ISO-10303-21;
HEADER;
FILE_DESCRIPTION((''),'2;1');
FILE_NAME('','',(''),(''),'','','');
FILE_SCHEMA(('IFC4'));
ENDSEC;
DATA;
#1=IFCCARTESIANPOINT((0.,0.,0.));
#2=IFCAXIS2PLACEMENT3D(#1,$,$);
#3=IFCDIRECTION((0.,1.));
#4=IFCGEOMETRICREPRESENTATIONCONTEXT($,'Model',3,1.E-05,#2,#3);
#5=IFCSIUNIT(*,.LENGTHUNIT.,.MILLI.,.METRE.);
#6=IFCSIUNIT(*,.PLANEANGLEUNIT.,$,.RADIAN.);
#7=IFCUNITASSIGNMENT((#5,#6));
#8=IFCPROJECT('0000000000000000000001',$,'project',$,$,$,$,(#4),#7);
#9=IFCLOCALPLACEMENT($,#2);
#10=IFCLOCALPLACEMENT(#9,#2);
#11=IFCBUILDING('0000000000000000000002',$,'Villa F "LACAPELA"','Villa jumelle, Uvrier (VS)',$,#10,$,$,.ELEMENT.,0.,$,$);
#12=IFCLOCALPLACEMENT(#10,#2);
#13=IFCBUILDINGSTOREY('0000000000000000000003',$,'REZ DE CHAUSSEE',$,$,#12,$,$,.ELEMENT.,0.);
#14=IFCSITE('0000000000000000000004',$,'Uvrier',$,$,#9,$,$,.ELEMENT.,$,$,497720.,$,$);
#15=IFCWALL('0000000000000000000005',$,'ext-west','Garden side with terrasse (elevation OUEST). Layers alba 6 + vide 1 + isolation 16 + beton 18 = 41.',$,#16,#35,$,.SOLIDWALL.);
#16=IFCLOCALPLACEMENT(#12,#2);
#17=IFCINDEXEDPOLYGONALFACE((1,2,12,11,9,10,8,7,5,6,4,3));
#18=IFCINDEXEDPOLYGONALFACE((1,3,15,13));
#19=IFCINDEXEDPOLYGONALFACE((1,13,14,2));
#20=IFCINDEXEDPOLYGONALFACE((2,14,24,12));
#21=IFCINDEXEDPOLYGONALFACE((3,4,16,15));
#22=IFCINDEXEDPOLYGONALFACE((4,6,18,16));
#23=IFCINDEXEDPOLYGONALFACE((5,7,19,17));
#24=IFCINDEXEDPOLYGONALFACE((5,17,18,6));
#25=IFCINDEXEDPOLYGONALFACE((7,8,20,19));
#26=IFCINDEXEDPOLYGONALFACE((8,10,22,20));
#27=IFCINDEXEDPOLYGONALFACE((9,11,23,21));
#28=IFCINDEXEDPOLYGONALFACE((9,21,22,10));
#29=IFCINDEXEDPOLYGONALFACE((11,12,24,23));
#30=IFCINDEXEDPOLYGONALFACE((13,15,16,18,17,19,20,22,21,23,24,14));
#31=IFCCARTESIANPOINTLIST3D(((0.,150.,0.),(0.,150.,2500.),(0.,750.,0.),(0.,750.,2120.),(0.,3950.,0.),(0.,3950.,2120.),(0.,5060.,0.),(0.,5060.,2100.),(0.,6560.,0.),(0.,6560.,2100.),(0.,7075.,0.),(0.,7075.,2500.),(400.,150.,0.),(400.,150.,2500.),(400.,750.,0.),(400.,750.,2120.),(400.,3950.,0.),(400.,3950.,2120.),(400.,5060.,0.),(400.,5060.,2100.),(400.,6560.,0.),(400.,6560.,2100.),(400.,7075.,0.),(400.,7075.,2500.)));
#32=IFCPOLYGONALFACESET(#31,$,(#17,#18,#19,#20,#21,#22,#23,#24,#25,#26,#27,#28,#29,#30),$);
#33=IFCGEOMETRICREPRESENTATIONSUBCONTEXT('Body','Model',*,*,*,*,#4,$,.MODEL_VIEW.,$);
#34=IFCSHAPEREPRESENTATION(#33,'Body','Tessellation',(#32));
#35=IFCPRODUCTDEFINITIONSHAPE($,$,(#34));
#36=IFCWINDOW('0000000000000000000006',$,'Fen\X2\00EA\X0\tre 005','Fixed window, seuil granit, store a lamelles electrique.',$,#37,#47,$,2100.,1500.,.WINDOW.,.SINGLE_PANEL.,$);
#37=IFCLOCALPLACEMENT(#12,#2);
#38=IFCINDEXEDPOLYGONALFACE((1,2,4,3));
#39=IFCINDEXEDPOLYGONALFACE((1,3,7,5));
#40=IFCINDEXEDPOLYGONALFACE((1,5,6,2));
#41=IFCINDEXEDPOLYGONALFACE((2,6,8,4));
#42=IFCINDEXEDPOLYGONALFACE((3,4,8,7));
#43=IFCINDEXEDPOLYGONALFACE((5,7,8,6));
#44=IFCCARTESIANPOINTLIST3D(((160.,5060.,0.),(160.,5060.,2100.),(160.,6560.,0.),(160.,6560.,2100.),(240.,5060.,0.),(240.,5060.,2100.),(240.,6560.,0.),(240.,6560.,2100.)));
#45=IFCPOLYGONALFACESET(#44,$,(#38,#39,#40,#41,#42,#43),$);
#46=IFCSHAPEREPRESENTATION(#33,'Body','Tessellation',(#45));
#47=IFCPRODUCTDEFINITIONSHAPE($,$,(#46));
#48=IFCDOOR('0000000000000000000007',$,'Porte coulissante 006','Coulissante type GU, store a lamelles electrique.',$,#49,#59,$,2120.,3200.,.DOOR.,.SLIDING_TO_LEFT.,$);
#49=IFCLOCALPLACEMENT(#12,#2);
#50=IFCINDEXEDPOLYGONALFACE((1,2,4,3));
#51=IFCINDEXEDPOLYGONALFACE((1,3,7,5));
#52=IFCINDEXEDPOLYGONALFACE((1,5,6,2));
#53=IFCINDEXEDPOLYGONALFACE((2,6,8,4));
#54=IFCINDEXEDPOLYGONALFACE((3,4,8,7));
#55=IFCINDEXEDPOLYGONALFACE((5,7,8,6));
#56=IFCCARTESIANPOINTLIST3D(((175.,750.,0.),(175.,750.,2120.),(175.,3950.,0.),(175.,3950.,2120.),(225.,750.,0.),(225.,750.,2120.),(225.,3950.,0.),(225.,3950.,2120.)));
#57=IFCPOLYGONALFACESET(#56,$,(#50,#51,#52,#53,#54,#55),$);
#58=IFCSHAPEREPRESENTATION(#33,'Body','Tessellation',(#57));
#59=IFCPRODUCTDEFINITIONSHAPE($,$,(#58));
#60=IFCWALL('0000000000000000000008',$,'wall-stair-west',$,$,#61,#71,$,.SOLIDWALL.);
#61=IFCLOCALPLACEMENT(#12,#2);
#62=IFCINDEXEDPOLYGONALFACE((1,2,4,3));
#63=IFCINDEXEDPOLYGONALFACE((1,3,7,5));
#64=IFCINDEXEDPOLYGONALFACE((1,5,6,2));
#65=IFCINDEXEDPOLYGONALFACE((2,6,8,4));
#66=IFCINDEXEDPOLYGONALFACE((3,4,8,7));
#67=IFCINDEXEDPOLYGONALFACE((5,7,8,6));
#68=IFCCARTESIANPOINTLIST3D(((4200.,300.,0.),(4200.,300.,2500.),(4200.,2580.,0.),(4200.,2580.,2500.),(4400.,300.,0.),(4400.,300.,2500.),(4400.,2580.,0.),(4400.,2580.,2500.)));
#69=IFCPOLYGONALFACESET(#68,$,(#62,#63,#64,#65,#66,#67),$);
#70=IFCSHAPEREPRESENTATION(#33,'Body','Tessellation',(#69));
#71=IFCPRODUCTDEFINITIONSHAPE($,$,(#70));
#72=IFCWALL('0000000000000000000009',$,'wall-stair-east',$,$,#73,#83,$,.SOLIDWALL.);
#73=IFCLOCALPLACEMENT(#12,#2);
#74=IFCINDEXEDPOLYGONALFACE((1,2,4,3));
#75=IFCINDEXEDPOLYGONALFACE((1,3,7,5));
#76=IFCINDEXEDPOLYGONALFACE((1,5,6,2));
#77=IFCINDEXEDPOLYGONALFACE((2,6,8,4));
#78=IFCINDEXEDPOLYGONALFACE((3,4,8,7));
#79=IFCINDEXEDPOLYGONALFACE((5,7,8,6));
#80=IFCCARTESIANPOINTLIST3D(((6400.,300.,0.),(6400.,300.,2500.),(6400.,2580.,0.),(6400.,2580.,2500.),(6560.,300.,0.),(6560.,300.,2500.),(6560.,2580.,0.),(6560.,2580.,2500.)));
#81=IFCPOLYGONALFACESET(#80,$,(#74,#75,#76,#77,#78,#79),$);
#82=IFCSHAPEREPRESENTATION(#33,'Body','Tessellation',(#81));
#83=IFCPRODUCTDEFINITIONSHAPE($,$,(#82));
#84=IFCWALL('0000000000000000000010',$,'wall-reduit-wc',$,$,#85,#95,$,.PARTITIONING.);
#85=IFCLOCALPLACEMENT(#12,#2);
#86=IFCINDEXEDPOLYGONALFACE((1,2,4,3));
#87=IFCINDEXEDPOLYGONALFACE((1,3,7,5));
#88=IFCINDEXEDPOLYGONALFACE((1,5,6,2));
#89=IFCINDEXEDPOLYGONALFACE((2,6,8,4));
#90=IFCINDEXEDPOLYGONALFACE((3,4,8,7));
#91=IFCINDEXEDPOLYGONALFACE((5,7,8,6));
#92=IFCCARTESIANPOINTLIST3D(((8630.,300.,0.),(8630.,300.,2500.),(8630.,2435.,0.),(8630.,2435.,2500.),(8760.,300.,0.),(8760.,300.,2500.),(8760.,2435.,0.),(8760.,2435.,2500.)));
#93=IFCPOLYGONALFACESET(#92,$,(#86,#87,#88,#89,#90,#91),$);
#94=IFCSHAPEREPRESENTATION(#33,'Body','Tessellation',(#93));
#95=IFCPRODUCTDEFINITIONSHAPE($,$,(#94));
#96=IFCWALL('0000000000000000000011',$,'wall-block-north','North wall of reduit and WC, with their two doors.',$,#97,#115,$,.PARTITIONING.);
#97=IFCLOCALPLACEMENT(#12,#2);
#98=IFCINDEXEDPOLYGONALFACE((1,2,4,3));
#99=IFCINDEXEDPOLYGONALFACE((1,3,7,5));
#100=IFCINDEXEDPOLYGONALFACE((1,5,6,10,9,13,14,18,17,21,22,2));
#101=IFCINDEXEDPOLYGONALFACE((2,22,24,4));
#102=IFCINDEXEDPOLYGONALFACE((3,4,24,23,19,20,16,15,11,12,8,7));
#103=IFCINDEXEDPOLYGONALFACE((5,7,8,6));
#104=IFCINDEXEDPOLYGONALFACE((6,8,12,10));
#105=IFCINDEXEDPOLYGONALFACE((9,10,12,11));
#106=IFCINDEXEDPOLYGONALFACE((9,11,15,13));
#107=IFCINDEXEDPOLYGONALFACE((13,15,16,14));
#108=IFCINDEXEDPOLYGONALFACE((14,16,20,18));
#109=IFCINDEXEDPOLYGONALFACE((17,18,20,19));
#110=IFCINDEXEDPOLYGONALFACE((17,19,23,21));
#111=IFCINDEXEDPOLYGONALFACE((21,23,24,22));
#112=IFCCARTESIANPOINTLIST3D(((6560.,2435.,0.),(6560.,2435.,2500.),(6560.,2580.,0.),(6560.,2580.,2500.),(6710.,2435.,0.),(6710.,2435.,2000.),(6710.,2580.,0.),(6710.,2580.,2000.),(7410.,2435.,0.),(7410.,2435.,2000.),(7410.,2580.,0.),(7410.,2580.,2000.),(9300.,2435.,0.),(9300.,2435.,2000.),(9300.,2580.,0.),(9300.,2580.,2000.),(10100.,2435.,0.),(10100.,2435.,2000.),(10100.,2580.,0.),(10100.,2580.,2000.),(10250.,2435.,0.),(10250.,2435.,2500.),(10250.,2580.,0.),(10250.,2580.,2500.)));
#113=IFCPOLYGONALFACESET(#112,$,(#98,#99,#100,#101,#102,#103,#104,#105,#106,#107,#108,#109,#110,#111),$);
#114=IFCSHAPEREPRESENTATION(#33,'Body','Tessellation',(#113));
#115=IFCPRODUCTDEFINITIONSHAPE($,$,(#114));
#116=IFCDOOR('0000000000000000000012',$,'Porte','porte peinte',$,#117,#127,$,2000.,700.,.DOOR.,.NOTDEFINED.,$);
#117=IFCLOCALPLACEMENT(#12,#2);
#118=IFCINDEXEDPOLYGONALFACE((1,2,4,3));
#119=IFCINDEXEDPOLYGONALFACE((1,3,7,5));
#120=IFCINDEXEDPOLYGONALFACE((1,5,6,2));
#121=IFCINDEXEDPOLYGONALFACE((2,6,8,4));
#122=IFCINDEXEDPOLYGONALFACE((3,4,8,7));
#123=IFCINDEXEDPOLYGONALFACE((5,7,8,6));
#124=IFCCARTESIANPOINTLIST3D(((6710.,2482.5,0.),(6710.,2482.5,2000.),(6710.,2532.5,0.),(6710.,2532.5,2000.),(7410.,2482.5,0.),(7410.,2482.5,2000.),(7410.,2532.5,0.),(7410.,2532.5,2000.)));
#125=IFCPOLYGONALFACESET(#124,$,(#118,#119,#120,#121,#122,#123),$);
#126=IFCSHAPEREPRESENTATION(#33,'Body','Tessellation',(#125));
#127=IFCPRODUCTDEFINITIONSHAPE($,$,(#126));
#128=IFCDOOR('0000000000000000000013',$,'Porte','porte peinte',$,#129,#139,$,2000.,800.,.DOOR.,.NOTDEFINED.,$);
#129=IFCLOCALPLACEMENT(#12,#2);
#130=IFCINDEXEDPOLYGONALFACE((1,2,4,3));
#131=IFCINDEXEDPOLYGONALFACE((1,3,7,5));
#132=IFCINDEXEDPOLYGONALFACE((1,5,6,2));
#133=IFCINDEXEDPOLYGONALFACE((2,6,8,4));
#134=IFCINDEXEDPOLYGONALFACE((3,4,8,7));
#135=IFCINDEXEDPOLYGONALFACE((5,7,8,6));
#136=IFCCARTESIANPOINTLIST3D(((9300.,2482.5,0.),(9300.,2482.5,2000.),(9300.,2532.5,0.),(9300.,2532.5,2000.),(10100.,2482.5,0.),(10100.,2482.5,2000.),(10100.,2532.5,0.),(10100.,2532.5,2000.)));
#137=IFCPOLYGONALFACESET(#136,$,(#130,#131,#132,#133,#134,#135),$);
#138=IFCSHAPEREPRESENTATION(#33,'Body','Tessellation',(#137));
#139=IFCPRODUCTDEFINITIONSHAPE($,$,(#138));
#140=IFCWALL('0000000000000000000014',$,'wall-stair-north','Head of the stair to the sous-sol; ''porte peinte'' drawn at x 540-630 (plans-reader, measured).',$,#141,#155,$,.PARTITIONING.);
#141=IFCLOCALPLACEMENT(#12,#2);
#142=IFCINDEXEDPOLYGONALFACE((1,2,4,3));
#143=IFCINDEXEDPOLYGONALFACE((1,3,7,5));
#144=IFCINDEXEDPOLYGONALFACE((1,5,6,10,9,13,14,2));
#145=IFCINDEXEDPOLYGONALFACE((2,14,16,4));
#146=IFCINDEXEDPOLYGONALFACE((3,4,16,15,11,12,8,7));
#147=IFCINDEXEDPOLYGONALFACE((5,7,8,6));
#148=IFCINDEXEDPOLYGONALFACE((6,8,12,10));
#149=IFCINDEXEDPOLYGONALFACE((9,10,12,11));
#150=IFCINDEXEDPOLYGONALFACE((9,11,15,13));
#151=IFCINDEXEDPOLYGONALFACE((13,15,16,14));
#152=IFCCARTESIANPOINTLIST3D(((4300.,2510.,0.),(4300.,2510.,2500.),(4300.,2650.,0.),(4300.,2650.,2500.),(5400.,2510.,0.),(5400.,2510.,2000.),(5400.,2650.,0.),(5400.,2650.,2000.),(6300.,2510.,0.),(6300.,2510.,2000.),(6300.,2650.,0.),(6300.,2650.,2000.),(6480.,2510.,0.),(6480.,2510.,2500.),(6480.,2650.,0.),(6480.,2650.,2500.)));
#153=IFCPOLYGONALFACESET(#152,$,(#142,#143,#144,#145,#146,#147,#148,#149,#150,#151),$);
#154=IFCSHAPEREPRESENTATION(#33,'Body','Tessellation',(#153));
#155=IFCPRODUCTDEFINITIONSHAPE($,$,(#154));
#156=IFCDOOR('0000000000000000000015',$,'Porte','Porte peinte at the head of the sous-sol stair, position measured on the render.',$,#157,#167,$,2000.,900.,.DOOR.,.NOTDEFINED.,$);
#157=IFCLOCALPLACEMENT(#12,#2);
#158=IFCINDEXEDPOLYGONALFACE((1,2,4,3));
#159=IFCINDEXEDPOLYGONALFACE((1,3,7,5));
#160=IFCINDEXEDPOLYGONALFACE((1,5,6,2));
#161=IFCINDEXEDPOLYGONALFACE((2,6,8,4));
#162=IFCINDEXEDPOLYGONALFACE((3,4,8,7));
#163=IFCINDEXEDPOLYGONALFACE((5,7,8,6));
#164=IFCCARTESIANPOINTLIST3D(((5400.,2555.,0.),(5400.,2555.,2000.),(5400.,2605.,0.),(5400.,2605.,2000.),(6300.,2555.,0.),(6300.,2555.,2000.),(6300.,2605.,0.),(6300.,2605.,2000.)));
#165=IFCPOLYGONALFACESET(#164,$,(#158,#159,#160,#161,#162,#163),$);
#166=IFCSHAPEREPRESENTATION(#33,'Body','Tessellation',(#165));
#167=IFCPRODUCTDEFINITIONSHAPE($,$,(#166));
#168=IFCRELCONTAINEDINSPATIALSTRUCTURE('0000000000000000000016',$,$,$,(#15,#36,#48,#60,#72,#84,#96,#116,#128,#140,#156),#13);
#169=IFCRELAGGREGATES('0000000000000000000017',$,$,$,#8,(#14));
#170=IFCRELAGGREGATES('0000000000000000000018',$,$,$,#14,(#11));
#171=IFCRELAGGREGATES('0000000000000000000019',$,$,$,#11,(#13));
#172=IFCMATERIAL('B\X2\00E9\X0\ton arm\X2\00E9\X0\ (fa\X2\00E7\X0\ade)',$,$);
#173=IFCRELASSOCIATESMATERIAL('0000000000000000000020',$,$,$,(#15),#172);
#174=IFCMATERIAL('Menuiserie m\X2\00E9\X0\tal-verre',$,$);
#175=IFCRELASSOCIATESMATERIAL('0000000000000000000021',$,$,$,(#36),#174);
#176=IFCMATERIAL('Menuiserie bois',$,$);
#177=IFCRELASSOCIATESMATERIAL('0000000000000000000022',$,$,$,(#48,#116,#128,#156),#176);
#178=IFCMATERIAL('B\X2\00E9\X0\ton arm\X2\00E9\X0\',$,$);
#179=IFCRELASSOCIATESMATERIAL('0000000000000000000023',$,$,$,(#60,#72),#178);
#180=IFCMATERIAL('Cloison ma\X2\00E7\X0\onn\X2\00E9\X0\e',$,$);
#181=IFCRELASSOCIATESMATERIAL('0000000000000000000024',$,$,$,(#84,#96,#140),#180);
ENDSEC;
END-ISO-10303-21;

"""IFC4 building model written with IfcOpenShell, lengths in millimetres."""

from ifc_helpers import new_model, si_unit, direction, frame, frame_2d, origin, place, context, subcontext, project, spatial, rectangle, extrude, material, element, fill, save


model = new_model("IFC4")

# Units and contexts
model_context = context("Model", 3, precision=1e-05, world=origin(), true_north=direction((0.0, 1.0)))
body_context = subcontext(model_context, "Body", "Model", "MODEL_VIEW")
ifc_project = project(units=[si_unit("LENGTHUNIT", "METRE", prefix="MILLI"), si_unit("PLANEANGLEUNIT", "RADIAN")], contexts=[model_context])

# Site, building, storey
site_placement = place(None, origin())
site = spatial("IfcSite", under=ifc_project, at=site_placement, Name="Uvrier", CompositionType="ELEMENT", RefElevation=497720.0)
building_placement = place(site_placement, origin())
building = spatial("IfcBuilding", under=site, at=building_placement, Name="Villa F \"LACAPELA\"", Description="Villa jumelle, Uvrier (VS)", CompositionType="ELEMENT", ElevationOfRefHeight=0.0)
storey_placement = place(building_placement, origin())
storey = spatial("IfcBuildingStorey", under=building, at=storey_placement, Name="REZ DE CHAUSSEE", CompositionType="ELEMENT", Elevation=0.0)

# Shared definitions
ifc_material_1 = material(Name="Béton armé")

# Shared definitions
ifc_material_2 = material(Name="Béton armé (façade)")

# Shared definitions
ifc_material_3 = material(Name="Menuiserie métal-verre")
ifc_material_4 = material(Name="Menuiserie bois")

# Wall, openings, window, door
wall_1_placement = place(storey_placement, frame((200.0, 150.0, 0.0), z_axis=(0.0, 0.0, 1.0), x_axis=(0.0, 1.0, 0.0)))
wall_1 = element("IfcWall", 1, at=wall_1_placement, inside=storey, material=ifc_material_2, Name="ext-west", Description="Garden side with terrasse (elevation OUEST). Layers alba 6 + vide 1 + isolation 16 + beton 18 = 41.", PredefinedType="SOLIDWALL", context=body_context, shape_type="SweptSolid", body=[
    extrude(rectangle(XDim=6925.0, YDim=400.0, at=frame_2d((3462.5, 0.0))), origin(), (0.0, 0.0, 1.0), 2500.0),
])
opening_1_placement = place(wall_1_placement, frame((4910.0, 0.0, 0.0)))
opening_1 = element("IfcOpeningElement", 2, at=opening_1_placement, cuts=wall_1, PredefinedType="OPENING", context=body_context, shape_type="SweptSolid", body=[
    extrude(rectangle(XDim=1500.0, YDim=600.0, at=frame_2d((750.0, 0.0))), origin(), (0.0, 0.0, 1.0), 2100.0),
])
opening_2_placement = place(wall_1_placement, frame((600.0, 0.0, 0.0)))
opening_2 = element("IfcOpeningElement", 3, at=opening_2_placement, cuts=wall_1, PredefinedType="OPENING", context=body_context, shape_type="SweptSolid", body=[
    extrude(rectangle(XDim=3200.0, YDim=600.0, at=frame_2d((1600.0, 0.0))), origin(), (0.0, 0.0, 1.0), 2120.0),
])
window_1_placement = place(opening_1_placement, origin())
window_1 = element("IfcWindow", 4, at=window_1_placement, inside=storey, material=ifc_material_3, Name="Fenêtre 005", Description="Fixed window, seuil granit, store a lamelles electrique.", OverallHeight=2100.0, OverallWidth=1500.0, PartitioningType="SINGLE_PANEL", PredefinedType="WINDOW", context=body_context, shape_type="SweptSolid", body=[
    extrude(rectangle(XDim=1500.0, YDim=80.0, at=frame_2d((750.0, 0.0))), origin(), (0.0, 0.0, 1.0), 2100.0),
])
fill(opening_1, window_1)
door_1_placement = place(opening_2_placement, origin())
door_1 = element("IfcDoor", 5, at=door_1_placement, inside=storey, material=ifc_material_4, Name="Porte coulissante 006", Description="Coulissante type GU, store a lamelles electrique.", OperationType="SLIDING_TO_LEFT", OverallHeight=2120.0, OverallWidth=3200.0, PredefinedType="DOOR", context=body_context, shape_type="SweptSolid", body=[
    extrude(rectangle(XDim=3200.0, YDim=50.0, at=frame_2d((1600.0, 0.0))), origin(), (0.0, 0.0, 1.0), 2120.0),
])
fill(opening_2, door_1)

# Walls
wall_2_placement = place(storey_placement, frame((4300.0, 300.0, 0.0), z_axis=(0.0, 0.0, 1.0), x_axis=(0.0, 1.0, 0.0)))
element("IfcWall", 6, at=wall_2_placement, inside=storey, material=ifc_material_1, Name="wall-stair-west", PredefinedType="SOLIDWALL", context=body_context, shape_type="SweptSolid", body=[
    extrude(rectangle(XDim=2280.0, YDim=200.0, at=frame_2d((1140.0, 0.0))), origin(), (0.0, 0.0, 1.0), 2500.0),
])
wall_3_placement = place(storey_placement, frame((6480.0, 300.0, 0.0), z_axis=(0.0, 0.0, 1.0), x_axis=(0.0, 1.0, 0.0)))
element("IfcWall", 7, at=wall_3_placement, inside=storey, material=ifc_material_1, Name="wall-stair-east", PredefinedType="SOLIDWALL", context=body_context, shape_type="SweptSolid", body=[
    extrude(rectangle(XDim=2280.0, YDim=160.0, at=frame_2d((1140.0, 0.0))), origin(), (0.0, 0.0, 1.0), 2500.0),
])
ifc_material_5 = material(Name="Cloison maçonnée")
wall_4_placement = place(storey_placement, frame((8695.0, 300.0, 0.0), z_axis=(0.0, 0.0, 1.0), x_axis=(0.0, 1.0, 0.0)))
element("IfcWall", 8, at=wall_4_placement, inside=storey, material=ifc_material_5, Name="wall-reduit-wc", PredefinedType="PARTITIONING", context=body_context, shape_type="SweptSolid", body=[
    extrude(rectangle(XDim=2135.0, YDim=130.0, at=frame_2d((1067.5, 0.0))), origin(), (0.0, 0.0, 1.0), 2500.0),
])

# Wall, openings, doors
wall_5_placement = place(storey_placement, frame((6560.0, 2507.5, 0.0), z_axis=(0.0, 0.0, 1.0), x_axis=(1.0, 0.0, 0.0)))
wall_5 = element("IfcWall", 9, at=wall_5_placement, inside=storey, material=ifc_material_5, Name="wall-block-north", Description="North wall of reduit and WC, with their two doors.", PredefinedType="PARTITIONING", context=body_context, shape_type="SweptSolid", body=[
    extrude(rectangle(XDim=3690.0, YDim=145.0, at=frame_2d((1845.0, 0.0))), origin(), (0.0, 0.0, 1.0), 2500.0),
])
opening_3_placement = place(wall_5_placement, frame((150.0, 0.0, 0.0)))
opening_3 = element("IfcOpeningElement", 10, at=opening_3_placement, cuts=wall_5, PredefinedType="OPENING", context=body_context, shape_type="SweptSolid", body=[
    extrude(rectangle(XDim=700.0, YDim=345.0, at=frame_2d((350.0, 0.0))), origin(), (0.0, 0.0, 1.0), 2000.0),
])
opening_4_placement = place(wall_5_placement, frame((2740.0, 0.0, 0.0)))
opening_4 = element("IfcOpeningElement", 11, at=opening_4_placement, cuts=wall_5, PredefinedType="OPENING", context=body_context, shape_type="SweptSolid", body=[
    extrude(rectangle(XDim=800.0, YDim=345.0, at=frame_2d((400.0, 0.0))), origin(), (0.0, 0.0, 1.0), 2000.0),
])
door_2_placement = place(opening_3_placement, origin())
door_2 = element("IfcDoor", 12, at=door_2_placement, inside=storey, material=ifc_material_4, Name="Porte", Description="porte peinte", OperationType="NOTDEFINED", OverallHeight=2000.0, OverallWidth=700.0, PredefinedType="DOOR", context=body_context, shape_type="SweptSolid", body=[
    extrude(rectangle(XDim=700.0, YDim=50.0, at=frame_2d((350.0, 0.0))), origin(), (0.0, 0.0, 1.0), 2000.0),
])
fill(opening_3, door_2)
door_3_placement = place(opening_4_placement, origin())
door_3 = element("IfcDoor", 13, at=door_3_placement, inside=storey, material=ifc_material_4, Name="Porte", Description="porte peinte", OperationType="NOTDEFINED", OverallHeight=2000.0, OverallWidth=800.0, PredefinedType="DOOR", context=body_context, shape_type="SweptSolid", body=[
    extrude(rectangle(XDim=800.0, YDim=50.0, at=frame_2d((400.0, 0.0))), origin(), (0.0, 0.0, 1.0), 2000.0),
])
fill(opening_4, door_3)

# Wall, opening, door
wall_6_placement = place(storey_placement, frame((4300.0, 2580.0, 0.0), z_axis=(0.0, 0.0, 1.0), x_axis=(1.0, 0.0, 0.0)))
wall_6 = element("IfcWall", 14, at=wall_6_placement, inside=storey, material=ifc_material_5, Name="wall-stair-north", Description="Head of the stair to the sous-sol; 'porte peinte' drawn at x 540-630 (plans-reader, measured).", PredefinedType="PARTITIONING", context=body_context, shape_type="SweptSolid", body=[
    extrude(rectangle(XDim=2180.0, YDim=140.0, at=frame_2d((1090.0, 0.0))), origin(), (0.0, 0.0, 1.0), 2500.0),
])
opening_5_placement = place(wall_6_placement, frame((1100.0, 0.0, 0.0)))
opening_5 = element("IfcOpeningElement", 15, at=opening_5_placement, cuts=wall_6, PredefinedType="OPENING", context=body_context, shape_type="SweptSolid", body=[
    extrude(rectangle(XDim=900.0, YDim=340.0, at=frame_2d((450.0, 0.0))), origin(), (0.0, 0.0, 1.0), 2000.0),
])
door_4_placement = place(opening_5_placement, origin())
door_4 = element("IfcDoor", 16, at=door_4_placement, inside=storey, material=ifc_material_4, Name="Porte", Description="Porte peinte at the head of the sous-sol stair, position measured on the render.", OperationType="NOTDEFINED", OverallHeight=2000.0, OverallWidth=900.0, PredefinedType="DOOR", context=body_context, shape_type="SweptSolid", body=[
    extrude(rectangle(XDim=900.0, YDim=50.0, at=frame_2d((450.0, 0.0))), origin(), (0.0, 0.0, 1.0), 2000.0),
])
fill(opening_5, door_4)

save(model, "model.ifc")
